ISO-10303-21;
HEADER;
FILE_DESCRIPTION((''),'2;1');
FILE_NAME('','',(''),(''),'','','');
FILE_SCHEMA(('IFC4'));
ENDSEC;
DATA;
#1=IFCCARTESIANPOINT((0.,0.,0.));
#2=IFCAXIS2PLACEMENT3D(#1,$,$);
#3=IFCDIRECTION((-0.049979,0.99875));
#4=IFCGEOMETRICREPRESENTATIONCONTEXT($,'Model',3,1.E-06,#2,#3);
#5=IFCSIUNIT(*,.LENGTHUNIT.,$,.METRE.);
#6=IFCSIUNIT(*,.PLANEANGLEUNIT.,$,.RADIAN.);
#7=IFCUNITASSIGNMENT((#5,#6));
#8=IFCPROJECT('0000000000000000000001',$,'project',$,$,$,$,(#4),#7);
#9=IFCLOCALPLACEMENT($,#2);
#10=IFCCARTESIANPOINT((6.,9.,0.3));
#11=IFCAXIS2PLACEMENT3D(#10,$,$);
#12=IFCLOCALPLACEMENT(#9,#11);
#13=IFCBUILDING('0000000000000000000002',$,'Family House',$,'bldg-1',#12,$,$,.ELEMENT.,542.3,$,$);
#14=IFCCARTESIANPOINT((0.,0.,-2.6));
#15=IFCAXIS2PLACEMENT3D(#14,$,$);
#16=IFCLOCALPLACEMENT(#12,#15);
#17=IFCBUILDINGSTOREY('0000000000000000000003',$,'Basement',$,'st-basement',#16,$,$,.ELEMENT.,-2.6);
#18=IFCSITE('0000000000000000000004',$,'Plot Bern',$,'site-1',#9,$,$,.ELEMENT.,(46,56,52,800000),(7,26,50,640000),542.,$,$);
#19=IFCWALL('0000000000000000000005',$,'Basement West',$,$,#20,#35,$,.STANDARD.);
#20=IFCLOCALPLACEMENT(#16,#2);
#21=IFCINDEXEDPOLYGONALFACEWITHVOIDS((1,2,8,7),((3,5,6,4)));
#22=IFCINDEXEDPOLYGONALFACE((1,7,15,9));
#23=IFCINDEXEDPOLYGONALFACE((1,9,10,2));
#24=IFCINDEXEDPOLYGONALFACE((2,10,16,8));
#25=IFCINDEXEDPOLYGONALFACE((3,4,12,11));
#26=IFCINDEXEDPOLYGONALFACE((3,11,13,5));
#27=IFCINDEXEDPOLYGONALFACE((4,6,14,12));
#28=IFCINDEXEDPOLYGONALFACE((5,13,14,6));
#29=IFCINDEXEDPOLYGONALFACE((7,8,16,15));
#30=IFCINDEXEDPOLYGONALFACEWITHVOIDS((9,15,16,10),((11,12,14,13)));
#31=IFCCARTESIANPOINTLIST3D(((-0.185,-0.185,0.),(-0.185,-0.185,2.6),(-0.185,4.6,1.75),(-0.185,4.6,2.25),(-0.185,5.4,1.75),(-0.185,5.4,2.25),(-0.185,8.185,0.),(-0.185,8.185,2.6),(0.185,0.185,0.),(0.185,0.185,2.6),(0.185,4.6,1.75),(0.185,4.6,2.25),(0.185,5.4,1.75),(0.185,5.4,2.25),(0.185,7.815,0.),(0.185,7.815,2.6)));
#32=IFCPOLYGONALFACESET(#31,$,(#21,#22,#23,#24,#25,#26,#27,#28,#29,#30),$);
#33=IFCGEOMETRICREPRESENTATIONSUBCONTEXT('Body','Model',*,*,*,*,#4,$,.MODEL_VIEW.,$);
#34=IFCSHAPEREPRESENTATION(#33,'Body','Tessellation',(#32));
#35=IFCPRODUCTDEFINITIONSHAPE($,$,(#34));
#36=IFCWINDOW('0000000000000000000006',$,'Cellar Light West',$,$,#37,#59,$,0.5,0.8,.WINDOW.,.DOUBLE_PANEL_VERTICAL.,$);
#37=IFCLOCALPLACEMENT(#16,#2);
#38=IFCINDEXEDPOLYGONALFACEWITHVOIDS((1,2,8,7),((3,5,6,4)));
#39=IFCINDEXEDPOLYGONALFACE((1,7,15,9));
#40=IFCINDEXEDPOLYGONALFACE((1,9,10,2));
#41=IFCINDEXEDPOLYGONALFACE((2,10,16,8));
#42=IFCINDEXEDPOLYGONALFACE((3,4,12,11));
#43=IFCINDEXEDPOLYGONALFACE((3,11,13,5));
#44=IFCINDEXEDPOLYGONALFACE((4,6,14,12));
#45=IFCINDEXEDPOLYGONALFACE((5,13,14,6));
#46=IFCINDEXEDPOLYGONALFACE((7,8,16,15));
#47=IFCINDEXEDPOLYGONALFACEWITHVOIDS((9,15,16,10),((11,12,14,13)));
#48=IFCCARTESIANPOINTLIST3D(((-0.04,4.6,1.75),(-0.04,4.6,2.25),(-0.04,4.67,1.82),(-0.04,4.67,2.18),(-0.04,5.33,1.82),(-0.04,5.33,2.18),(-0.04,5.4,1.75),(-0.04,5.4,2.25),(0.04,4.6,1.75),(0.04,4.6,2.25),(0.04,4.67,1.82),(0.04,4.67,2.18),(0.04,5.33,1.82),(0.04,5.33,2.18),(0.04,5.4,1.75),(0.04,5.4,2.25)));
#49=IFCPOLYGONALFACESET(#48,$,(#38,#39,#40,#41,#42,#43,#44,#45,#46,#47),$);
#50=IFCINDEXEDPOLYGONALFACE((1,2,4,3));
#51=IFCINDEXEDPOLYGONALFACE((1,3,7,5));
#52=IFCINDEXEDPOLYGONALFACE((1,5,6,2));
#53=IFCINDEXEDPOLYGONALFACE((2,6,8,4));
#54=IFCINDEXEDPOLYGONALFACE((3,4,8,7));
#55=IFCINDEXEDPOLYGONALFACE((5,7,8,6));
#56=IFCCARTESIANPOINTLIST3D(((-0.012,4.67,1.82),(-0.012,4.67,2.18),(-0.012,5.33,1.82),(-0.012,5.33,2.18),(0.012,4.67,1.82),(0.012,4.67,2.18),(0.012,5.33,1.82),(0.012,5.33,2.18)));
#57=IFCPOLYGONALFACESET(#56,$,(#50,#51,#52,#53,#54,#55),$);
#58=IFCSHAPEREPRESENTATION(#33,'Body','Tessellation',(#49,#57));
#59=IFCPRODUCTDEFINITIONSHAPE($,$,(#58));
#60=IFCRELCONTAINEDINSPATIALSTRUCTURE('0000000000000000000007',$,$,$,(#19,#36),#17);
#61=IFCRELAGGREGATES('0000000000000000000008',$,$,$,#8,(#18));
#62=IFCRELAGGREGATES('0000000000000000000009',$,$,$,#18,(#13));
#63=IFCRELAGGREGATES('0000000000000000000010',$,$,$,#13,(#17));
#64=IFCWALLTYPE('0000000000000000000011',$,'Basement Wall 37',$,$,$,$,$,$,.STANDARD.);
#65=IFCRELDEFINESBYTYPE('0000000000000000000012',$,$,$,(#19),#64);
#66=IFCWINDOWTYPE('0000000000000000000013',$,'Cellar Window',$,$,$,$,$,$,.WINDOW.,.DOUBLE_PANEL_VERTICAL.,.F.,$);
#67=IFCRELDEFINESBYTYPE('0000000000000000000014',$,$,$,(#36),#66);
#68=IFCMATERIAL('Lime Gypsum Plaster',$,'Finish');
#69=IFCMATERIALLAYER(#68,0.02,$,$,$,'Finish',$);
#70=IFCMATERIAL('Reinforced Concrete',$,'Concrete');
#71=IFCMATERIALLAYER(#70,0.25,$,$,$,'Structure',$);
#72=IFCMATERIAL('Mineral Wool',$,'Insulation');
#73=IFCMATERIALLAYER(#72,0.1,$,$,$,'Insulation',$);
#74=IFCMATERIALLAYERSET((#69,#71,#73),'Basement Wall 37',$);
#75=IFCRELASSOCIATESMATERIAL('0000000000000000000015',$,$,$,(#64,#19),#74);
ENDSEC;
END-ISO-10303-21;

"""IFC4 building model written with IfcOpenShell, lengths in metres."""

from ifc_helpers import new_model, si_unit, direction, frame, frame_2d, origin, origin_2d, place, context, subcontext, project, spatial, polyline, rectangle, outline, extrude, material, layer, layer_set, layer_usage, type_object, element, fill, save


model = new_model("IFC4")

# Units and contexts
model_context = context("Model", 3, precision=1e-06, world=origin(), true_north=direction((-0.049979, 0.99875)))
body_context = subcontext(model_context, "Body", "Model", "MODEL_VIEW")
ifc_project = project(units=[si_unit("LENGTHUNIT", "METRE"), si_unit("PLANEANGLEUNIT", "RADIAN")], contexts=[model_context])

# Site, building, storey
site_placement = place(None, origin())
site = spatial("IfcSite", under=ifc_project, at=site_placement, Name="Plot Bern", ObjectType="site-1", CompositionType="ELEMENT", RefLatitude=(46, 56, 52, 800000), RefLongitude=(7, 26, 50, 640000), RefElevation=542.0)
building_placement = place(site_placement, frame((6.0, 9.0, 0.3)))
building = spatial("IfcBuilding", under=site, at=building_placement, Name="Family House", ObjectType="bldg-1", CompositionType="ELEMENT", ElevationOfRefHeight=542.3)
storey_placement = place(building_placement, frame((0.0, 0.0, -2.6)))
storey = spatial("IfcBuildingStorey", under=building, at=storey_placement, Name="Basement", ObjectType="st-basement", CompositionType="ELEMENT", Elevation=-2.6)

# Shared definitions
ifc_material_1 = material(Name="Mineral Wool", Category="Insulation")
ifc_material_2 = material(Name="Reinforced Concrete", Category="Concrete")

# Shared definitions
ifc_material_3 = material(Name="Lime Gypsum Plaster", Category="Finish")
ifc_layer_1 = layer(ifc_material_3, 0.02, Category="Finish")
ifc_layer_2 = layer(ifc_material_2, 0.25, Category="Structure")
ifc_layer_3 = layer(ifc_material_1, 0.1, Category="Insulation")
ifc_layer_set_1 = layer_set([ifc_layer_1, ifc_layer_2, ifc_layer_3], Name="Basement Wall 37")
wall_type_1 = type_object("IfcWallType", Name="Basement Wall 37", PredefinedType="STANDARD", material=ifc_layer_set_1)

# Shared definitions
window_type = type_object("IfcWindowType", Name="Cellar Window", ParameterTakesPrecedence=False, PartitioningType="DOUBLE_PANEL_VERTICAL", PredefinedType="WINDOW")

# Wall, opening, window
ifc_layer_usage_1 = layer_usage(ifc_layer_set_1, "AXIS2", "NEGATIVE", 0.185)
wall_1_placement = place(storey_placement, origin())
wall_1 = element("IfcWall", 1, at=wall_1_placement, inside=storey, type_object=wall_type_1, material=ifc_layer_usage_1, Name="Basement West", PredefinedType="STANDARD", context=body_context, shape_type="SweptSolid", body=[
    extrude(outline(polyline([(-0.185, 8.185), (-0.185, -0.185), (0.185, 0.185), (0.185, 7.815), (-0.185, 8.185)])), origin(), (0.0, 0.0, 1.0), 2.6),
])
opening_1_placement = place(wall_1_placement, frame((0.0, 5.0, 1.75), z_axis=(0.0, 0.0, 1.0), x_axis=(0.0, -1.0, 0.0)))
opening_1 = element("IfcOpeningElement", 2, at=opening_1_placement, cuts=wall_1, PredefinedType="OPENING", context=body_context, shape_type="SweptSolid", body=[
    extrude(rectangle(XDim=0.8, YDim=0.37, at=origin_2d()), origin(), (0.0, 0.0, 1.0), 0.5),
])
window_1_placement = place(opening_1_placement, frame((0.0, 0.0, 0.0), z_axis=(0.0, -1.0, 0.0), x_axis=(1.0, 0.0, 0.0)))
window_1 = element("IfcWindow", 3, at=window_1_placement, inside=storey, type_object=window_type, Name="Cellar Light West", OverallHeight=0.5, OverallWidth=0.8, PartitioningType="DOUBLE_PANEL_VERTICAL", PredefinedType="WINDOW", context=body_context, shape_type="SweptSolid", body=[
    extrude(outline(polyline([(-0.4, 0.0), (0.4, 0.0), (0.4, 0.5), (-0.4, 0.5), (-0.4, 0.0)]), holes=[polyline([(-0.33, 0.07), (0.33, 0.07), (0.33, 0.43), (-0.33, 0.43), (-0.33, 0.07)])]), frame((0.0, 0.0, -0.04)), (0.0, 0.0, 1.0), 0.08),
    extrude(rectangle(XDim=0.66, YDim=0.36, at=frame_2d((0.0, 0.25))), frame((0.0, 0.0, -0.012)), (0.0, 0.0, 1.0), 0.024),
])
fill(opening_1, window_1)

save(model, "model.ifc")
